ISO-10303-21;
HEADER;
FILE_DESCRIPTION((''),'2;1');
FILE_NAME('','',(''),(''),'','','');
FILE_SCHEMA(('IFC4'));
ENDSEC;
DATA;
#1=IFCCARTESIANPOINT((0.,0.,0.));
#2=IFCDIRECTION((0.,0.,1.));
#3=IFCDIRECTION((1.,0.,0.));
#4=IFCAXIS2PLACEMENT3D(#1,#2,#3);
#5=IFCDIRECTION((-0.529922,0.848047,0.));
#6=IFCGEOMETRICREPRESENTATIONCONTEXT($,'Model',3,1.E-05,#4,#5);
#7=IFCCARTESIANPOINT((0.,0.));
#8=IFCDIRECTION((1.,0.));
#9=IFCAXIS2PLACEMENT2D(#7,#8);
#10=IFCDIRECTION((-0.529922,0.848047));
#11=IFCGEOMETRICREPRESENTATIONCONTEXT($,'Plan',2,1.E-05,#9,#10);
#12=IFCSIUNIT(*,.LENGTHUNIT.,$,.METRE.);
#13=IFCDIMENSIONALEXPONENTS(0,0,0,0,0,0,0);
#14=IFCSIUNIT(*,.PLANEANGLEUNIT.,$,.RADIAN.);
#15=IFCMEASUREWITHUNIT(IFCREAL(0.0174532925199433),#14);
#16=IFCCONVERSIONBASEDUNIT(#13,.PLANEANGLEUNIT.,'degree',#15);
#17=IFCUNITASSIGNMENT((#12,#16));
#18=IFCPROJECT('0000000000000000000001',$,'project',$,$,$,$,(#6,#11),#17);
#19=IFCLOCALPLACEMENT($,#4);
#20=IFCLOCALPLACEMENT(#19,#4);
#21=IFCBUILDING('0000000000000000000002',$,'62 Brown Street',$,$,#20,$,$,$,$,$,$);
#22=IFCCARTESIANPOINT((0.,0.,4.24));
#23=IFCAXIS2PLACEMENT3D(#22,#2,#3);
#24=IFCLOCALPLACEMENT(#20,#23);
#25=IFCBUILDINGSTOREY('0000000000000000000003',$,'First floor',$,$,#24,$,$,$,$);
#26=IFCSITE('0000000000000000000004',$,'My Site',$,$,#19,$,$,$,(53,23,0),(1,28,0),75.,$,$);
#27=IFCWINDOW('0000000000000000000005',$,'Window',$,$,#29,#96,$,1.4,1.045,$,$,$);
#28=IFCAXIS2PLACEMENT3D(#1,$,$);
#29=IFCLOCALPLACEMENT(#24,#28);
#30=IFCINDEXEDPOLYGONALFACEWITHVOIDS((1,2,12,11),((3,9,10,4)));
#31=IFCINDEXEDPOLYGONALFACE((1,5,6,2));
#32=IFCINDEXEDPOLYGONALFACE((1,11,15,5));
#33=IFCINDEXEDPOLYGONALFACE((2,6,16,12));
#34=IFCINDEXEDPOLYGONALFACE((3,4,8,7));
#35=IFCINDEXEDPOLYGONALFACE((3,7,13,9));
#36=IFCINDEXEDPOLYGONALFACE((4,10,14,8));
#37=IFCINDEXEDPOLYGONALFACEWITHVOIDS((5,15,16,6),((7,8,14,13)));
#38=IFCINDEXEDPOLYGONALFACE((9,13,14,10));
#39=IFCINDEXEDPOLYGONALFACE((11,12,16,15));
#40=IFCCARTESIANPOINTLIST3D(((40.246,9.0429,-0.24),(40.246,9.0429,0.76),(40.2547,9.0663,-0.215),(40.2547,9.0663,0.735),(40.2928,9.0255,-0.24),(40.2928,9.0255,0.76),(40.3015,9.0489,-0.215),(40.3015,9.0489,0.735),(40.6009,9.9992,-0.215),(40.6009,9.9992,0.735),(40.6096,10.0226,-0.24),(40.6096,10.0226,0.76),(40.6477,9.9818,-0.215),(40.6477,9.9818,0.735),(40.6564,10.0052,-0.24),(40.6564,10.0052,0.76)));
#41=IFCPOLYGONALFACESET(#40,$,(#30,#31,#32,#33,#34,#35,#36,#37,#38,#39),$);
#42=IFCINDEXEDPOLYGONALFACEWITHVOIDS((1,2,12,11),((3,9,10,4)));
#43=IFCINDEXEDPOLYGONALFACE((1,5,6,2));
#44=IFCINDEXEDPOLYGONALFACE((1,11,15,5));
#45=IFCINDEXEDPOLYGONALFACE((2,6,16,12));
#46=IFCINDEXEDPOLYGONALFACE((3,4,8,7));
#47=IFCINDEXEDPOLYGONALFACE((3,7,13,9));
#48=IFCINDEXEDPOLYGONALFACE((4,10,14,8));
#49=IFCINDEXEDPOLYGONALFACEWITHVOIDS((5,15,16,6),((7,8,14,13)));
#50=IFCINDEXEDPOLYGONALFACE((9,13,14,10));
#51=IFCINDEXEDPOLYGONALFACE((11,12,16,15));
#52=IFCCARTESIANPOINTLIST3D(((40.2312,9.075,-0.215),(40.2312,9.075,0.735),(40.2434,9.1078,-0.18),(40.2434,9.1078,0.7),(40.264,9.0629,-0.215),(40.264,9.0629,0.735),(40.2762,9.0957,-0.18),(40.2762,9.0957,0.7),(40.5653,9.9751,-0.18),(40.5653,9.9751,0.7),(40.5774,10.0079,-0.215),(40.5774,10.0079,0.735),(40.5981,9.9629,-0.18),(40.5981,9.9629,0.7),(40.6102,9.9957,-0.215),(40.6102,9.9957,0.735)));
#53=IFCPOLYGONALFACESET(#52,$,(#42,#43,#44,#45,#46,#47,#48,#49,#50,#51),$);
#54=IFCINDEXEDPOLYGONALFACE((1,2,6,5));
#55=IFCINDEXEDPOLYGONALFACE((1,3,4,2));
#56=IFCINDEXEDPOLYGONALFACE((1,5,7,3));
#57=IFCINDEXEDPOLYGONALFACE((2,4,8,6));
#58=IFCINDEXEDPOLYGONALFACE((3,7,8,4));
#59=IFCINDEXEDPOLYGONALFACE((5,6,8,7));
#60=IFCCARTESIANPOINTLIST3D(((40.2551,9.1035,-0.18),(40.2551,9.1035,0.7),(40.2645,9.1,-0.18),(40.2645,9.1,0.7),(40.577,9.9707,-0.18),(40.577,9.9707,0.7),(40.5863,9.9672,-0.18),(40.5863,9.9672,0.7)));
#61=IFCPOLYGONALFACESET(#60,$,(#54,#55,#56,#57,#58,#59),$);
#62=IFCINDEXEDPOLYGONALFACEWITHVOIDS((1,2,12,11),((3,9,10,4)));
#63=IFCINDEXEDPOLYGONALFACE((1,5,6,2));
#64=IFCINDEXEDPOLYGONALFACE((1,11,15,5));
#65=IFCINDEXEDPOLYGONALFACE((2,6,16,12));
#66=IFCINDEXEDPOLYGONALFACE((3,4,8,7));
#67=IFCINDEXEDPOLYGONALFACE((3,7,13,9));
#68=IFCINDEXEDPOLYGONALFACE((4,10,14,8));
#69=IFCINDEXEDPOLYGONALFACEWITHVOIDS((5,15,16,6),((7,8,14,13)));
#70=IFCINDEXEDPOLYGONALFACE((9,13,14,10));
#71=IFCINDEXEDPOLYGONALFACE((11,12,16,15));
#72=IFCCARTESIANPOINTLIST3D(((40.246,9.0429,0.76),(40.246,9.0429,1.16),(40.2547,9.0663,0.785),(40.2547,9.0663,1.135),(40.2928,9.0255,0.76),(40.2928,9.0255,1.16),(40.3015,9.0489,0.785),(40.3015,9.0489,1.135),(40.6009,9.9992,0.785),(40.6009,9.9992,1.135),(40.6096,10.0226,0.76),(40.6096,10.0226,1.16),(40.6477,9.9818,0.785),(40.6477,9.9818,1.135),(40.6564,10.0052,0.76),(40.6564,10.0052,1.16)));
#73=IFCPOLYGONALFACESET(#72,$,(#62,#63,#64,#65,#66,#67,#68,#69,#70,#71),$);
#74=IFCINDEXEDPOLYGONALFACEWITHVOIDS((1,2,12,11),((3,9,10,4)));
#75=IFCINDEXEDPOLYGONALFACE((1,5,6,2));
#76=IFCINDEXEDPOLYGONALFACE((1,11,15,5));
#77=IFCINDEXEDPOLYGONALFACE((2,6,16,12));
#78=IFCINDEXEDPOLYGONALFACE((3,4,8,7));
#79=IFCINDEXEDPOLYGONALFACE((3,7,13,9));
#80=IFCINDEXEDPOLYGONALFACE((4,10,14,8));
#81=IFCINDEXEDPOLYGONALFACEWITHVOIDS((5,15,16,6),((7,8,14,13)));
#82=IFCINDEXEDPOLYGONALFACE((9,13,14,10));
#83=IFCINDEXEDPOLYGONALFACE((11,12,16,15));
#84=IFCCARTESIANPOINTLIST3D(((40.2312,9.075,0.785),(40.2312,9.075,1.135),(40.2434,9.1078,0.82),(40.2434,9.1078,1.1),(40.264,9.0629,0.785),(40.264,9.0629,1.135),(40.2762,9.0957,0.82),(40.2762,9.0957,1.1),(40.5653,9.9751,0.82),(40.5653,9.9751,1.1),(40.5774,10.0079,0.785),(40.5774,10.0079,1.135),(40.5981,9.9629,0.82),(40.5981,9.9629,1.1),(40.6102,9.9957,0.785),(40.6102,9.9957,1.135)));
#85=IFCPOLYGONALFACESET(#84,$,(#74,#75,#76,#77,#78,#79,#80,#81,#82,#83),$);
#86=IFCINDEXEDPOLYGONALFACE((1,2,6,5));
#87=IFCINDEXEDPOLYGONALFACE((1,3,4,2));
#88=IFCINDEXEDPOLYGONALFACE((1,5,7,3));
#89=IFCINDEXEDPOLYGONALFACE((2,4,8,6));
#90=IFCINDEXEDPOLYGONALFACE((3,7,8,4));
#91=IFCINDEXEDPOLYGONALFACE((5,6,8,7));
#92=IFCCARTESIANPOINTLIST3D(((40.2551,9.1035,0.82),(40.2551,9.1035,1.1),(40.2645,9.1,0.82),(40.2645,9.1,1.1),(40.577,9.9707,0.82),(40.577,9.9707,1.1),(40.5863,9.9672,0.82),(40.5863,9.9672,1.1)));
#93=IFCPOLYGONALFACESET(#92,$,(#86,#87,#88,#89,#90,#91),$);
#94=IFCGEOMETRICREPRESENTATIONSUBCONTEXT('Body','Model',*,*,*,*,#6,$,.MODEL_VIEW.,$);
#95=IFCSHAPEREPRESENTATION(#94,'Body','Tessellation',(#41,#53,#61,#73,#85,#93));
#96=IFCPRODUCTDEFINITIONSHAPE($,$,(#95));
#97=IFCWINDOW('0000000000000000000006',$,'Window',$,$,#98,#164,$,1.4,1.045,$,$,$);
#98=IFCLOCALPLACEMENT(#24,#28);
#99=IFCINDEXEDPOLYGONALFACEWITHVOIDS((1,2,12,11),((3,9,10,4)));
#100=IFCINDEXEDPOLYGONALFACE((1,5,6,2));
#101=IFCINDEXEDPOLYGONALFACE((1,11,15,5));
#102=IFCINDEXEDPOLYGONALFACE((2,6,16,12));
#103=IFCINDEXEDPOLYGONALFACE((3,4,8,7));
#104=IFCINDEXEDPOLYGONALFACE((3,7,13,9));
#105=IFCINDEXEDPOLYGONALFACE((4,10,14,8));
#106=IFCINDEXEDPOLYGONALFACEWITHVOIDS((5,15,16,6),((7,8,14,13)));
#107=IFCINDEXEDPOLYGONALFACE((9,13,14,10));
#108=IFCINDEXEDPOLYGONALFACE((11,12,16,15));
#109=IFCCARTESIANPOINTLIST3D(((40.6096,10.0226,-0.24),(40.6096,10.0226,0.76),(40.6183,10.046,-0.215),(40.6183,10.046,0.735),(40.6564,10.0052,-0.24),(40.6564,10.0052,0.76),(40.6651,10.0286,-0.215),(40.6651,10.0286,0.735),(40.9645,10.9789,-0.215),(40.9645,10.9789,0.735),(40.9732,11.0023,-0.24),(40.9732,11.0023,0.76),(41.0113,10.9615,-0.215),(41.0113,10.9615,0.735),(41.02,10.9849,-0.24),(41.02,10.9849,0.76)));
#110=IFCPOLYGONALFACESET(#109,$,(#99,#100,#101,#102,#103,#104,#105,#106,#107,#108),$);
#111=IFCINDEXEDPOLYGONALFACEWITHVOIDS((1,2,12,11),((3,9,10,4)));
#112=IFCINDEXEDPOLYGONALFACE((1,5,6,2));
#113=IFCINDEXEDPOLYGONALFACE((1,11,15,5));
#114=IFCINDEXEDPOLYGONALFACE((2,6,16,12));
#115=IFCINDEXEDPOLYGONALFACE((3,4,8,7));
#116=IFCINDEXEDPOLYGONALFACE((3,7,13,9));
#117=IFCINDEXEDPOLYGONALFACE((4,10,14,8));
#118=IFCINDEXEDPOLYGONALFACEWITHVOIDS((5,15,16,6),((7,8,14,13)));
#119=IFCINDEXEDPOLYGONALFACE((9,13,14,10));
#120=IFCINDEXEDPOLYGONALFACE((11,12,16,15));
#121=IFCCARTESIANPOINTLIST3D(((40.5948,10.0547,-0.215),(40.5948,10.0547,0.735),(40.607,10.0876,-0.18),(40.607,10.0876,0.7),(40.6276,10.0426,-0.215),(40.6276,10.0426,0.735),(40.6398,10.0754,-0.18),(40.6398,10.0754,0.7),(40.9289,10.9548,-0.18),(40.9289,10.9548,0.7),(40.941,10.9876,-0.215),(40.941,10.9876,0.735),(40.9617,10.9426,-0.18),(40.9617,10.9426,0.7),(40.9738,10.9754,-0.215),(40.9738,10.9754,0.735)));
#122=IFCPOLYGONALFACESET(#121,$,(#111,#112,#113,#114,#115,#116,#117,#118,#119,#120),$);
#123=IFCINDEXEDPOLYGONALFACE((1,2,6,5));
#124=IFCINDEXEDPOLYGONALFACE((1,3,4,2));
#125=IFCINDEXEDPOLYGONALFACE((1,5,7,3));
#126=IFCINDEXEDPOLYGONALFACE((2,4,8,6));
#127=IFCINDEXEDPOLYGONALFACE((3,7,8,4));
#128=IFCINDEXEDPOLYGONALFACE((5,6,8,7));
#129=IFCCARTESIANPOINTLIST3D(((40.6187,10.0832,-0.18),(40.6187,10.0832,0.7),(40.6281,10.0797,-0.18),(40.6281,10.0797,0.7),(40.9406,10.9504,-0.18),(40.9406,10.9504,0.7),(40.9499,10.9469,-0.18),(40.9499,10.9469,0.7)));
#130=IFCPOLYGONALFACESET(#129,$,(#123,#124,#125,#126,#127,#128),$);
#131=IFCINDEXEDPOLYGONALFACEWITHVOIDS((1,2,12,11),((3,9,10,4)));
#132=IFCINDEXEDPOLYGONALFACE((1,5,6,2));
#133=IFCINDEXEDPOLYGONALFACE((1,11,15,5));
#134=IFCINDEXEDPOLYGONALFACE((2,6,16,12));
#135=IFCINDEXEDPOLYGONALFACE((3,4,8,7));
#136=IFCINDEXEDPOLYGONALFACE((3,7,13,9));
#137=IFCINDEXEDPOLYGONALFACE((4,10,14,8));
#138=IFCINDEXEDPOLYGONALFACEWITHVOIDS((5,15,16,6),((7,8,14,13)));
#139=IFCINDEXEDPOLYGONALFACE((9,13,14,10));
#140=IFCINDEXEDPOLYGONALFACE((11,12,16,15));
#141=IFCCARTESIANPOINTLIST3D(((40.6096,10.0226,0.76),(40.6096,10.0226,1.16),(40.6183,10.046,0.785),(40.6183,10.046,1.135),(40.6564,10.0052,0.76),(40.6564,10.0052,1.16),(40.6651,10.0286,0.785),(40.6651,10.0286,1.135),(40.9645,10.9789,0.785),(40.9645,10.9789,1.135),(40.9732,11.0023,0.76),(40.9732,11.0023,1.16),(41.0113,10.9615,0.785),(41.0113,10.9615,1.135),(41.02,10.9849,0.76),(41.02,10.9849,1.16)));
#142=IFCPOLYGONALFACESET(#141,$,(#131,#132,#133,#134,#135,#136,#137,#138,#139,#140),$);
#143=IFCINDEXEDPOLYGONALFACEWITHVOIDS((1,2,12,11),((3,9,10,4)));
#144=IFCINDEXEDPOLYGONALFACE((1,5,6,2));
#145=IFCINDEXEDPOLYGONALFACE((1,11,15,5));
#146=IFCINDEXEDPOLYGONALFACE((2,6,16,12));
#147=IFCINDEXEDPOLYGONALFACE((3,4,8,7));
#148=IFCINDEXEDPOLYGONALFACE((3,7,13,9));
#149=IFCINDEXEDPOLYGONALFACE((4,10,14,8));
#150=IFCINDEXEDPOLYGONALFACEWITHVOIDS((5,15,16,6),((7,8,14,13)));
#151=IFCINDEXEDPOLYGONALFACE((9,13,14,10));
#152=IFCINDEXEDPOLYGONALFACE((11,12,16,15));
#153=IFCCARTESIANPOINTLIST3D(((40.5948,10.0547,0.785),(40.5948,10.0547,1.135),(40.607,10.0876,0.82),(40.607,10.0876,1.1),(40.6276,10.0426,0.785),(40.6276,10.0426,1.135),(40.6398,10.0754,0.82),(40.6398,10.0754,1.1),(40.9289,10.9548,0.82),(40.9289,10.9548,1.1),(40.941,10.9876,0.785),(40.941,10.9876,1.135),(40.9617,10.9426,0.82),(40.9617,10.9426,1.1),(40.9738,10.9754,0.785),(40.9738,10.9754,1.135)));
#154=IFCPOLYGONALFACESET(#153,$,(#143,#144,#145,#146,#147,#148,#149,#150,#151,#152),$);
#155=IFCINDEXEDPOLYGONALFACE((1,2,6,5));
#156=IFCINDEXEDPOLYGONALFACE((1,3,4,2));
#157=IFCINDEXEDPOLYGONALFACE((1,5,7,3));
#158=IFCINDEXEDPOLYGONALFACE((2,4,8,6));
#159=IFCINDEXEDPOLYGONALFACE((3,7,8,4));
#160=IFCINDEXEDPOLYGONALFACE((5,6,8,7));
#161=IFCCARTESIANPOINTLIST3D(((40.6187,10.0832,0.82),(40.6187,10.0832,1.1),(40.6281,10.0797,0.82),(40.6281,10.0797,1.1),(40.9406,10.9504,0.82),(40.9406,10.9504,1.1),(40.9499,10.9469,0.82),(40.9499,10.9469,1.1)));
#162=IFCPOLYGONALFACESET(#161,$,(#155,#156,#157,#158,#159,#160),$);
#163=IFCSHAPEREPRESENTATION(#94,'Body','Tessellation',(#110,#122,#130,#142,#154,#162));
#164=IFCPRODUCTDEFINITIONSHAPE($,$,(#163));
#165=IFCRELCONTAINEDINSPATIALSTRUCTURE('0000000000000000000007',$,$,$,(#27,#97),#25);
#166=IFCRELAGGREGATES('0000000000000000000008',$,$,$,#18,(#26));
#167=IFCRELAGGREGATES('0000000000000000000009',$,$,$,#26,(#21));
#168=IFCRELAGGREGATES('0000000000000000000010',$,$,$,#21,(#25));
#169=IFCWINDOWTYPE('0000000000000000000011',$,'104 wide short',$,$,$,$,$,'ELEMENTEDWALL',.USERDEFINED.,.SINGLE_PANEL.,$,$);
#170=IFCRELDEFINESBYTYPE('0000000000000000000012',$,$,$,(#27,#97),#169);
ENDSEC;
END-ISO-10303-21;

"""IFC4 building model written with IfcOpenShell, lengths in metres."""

from ifc_helpers import new_model, entity, si_unit, converted_unit, direction, frame, origin_with_axes, origin_2d_with_axis, place, context, subcontext, project, spatial, line, indexed_curve, outline, extrude, shape, source, transform, mapped, type_object, type_shapes, element, save


model = new_model("IFC4")

# Units and contexts
model_context = context("Model", 3, precision=1e-05, world=origin_with_axes(), true_north=direction((-0.529922, 0.848047, 0.0)))
plan_context = context("Plan", 2, precision=1e-05, world=origin_2d_with_axis(), true_north=direction((-0.529922, 0.848047)))
body_context_1 = subcontext(model_context, "Body", "Model", "MODEL_VIEW")
body_context_2 = subcontext(plan_context, "Body", "Plan", "PLAN_VIEW")
ifc_project = project(units=[si_unit("LENGTHUNIT", "METRE"), converted_unit("PLANEANGLEUNIT", "degree", entity("IfcReal", 0.0174532925199433), si_unit("PLANEANGLEUNIT", "RADIAN"), dimensions=[0, 0, 0, 0, 0, 0, 0])], contexts=[model_context, plan_context])

# Site, building, storey
site_placement = place(None, origin_with_axes())
site = spatial("IfcSite", under=ifc_project, at=site_placement, Name="My Site", RefLatitude=(53, 23, 0), RefLongitude=(1, 28, 0), RefElevation=75.0)
building_placement = place(site_placement, origin_with_axes())
building = spatial("IfcBuilding", under=site, at=building_placement, Name="62 Brown Street")
storey_placement = place(building_placement, frame((0.0, 0.0, 4.24), z_axis=(0.0, 0.0, 1.0), x_axis=(1.0, 0.0, 0.0)))
storey = spatial("IfcBuildingStorey", under=building, at=storey_placement, Name="First floor")

# Windows
window_type = type_object("IfcWindowType", Name="104 wide short", ElementType="ELEMENTEDWALL", PartitioningType="SINGLE_PANEL", PredefinedType="USERDEFINED")
shared_shape_1 = source(origin_with_axes(), body_context_1, "Body", "SweptSolid", [
    extrude(outline(indexed_curve([(0.0, 0.0), (1.045, 0.0), (1.045, 1.0), (0.0, 1.0)], segments=[line(1, 2, 3, 4, 1)]), holes=[indexed_curve([(0.025, 0.025), (1.02, 0.025), (1.02, 0.975), (0.025, 0.975)], segments=[line(1, 2, 3, 4, 1)])]), frame((0.0, 0.15, 0.0), z_axis=(0.0, -1.0, 0.0), x_axis=(1.0, 0.0, 0.0)), (0.0, 0.0, -1.0), 0.05),
    extrude(outline(indexed_curve([(0.0, 0.0), (0.995, 0.0), (0.995, 0.95), (0.0, 0.95)], segments=[line(1, 2, 3, 4, 1)]), holes=[indexed_curve([(0.035, 0.035), (0.96, 0.035), (0.96, 0.915), (0.035, 0.915)], segments=[line(1, 2, 3, 4, 1)])]), frame((0.025, 0.19, 0.025), z_axis=(0.0, -1.0, 0.0), x_axis=(1.0, 0.0, 0.0)), (0.0, 0.0, -1.0), 0.035),
    extrude(outline(indexed_curve([(0.035, 0.035), (0.96, 0.035), (0.96, 0.915), (0.035, 0.915)], segments=[line(1, 2, 3, 4, 1)])), frame((0.025, 0.2025, 0.025), z_axis=(0.0, -1.0, 0.0), x_axis=(1.0, 0.0, 0.0)), (0.0, 0.0, -1.0), 0.01),
    extrude(outline(indexed_curve([(0.0, 0.0), (1.045, 0.0), (1.045, 0.4), (0.0, 0.4)], segments=[line(1, 2, 3, 4, 1)]), holes=[indexed_curve([(0.025, 0.025), (1.02, 0.025), (1.02, 0.375), (0.025, 0.375)], segments=[line(1, 2, 3, 4, 1)])]), frame((0.0, 0.15, 1.0), z_axis=(0.0, -1.0, 0.0), x_axis=(1.0, 0.0, 0.0)), (0.0, 0.0, -1.0), 0.05),
    extrude(outline(indexed_curve([(0.0, 0.0), (0.995, 0.0), (0.995, 0.35), (0.0, 0.35)], segments=[line(1, 2, 3, 4, 1)]), holes=[indexed_curve([(0.035, 0.035), (0.96, 0.035), (0.96, 0.315), (0.035, 0.315)], segments=[line(1, 2, 3, 4, 1)])]), frame((0.025, 0.19, 1.025), z_axis=(0.0, -1.0, 0.0), x_axis=(1.0, 0.0, 0.0)), (0.0, 0.0, -1.0), 0.035),
    extrude(outline(indexed_curve([(0.035, 0.035), (0.96, 0.035), (0.96, 0.315), (0.035, 0.315)], segments=[line(1, 2, 3, 4, 1)])), frame((0.025, 0.2025, 1.025), z_axis=(0.0, -1.0, 0.0), x_axis=(1.0, 0.0, 0.0)), (0.0, 0.0, -1.0), 0.01),
])
shared_shape_2 = source(origin_with_axes(), body_context_2, "Body", "Curve2D", [
    entity("IfcIndexedPolyCurve", entity("IfcCartesianPointList2D", [[0.025, 0.15], [1.02, 0.15]])),
    entity("IfcIndexedPolyCurve", entity("IfcCartesianPointList2D", [[0.0, 0.2], [0.025, 0.2], [0.025, 0.15], [0.0, 0.15]]), [entity("IfcLineIndex", [1, 2, 3, 4, 1])]),
    entity("IfcIndexedPolyCurve", entity("IfcCartesianPointList2D", [[1.045, 0.2], [1.02, 0.2], [1.02, 0.15], [1.045, 0.15]]), [entity("IfcLineIndex", [1, 2, 3, 4, 1])]),
    entity("IfcIndexedPolyCurve", entity("IfcCartesianPointList2D", [[0.025, 0.19], [0.06, 0.19], [0.06, 0.225], [0.025, 0.225]]), [entity("IfcLineIndex", [1, 2, 3, 4, 1])]),
    entity("IfcIndexedPolyCurve", entity("IfcCartesianPointList2D", [[1.02, 0.19], [0.985, 0.19], [0.985, 0.225], [1.02, 0.225]]), [entity("IfcLineIndex", [1, 2, 3, 4, 1])]),
    entity("IfcIndexedPolyCurve", entity("IfcCartesianPointList2D", [[0.06, 0.19], [0.985, 0.19]])),
    entity("IfcIndexedPolyCurve", entity("IfcCartesianPointList2D", [[0.06, 0.225], [0.985, 0.225]])),
    entity("IfcIndexedPolyCurve", entity("IfcCartesianPointList2D", [[0.06, 0.2075], [0.985, 0.2075]])),
])
type_shapes(window_type, [shared_shape_1, shared_shape_2])
for number, where, z_axis, x_axis, name in (
    (1, (40.4335, 8.9733, -0.24), (0.0, 0.0, 1.0), (0.347944, 0.937515, 0.0), "Window"),
    (2, (40.7971, 9.953, -0.24), (0.0, 0.0, 1.0), (0.347944, 0.937515, 0.0), "Window"),
):
    element("IfcWindow", number, at=place(storey_placement, frame(where, z_axis=z_axis, x_axis=x_axis)), inside=storey, type_object=window_type, Name=name, OverallHeight=1.4, OverallWidth=1.045, shapes=[
        shape(body_context_1, "Body", "MappedRepresentation", [mapped(shared_shape_1, transform((0.0, 0.0, 0.0), x_axis=(1.0, 0.0, 0.0), y_axis=(0.0, 1.0, 0.0), z_axis=(0.0, 0.0, 1.0), scale=1.0))]),
        shape(body_context_2, "Body", "MappedRepresentation", [mapped(shared_shape_2, transform((0.0, 0.0, 0.0), x_axis=(1.0, 0.0, 0.0), y_axis=(0.0, 1.0, 0.0), z_axis=(0.0, 0.0, 1.0), scale=1.0))]),
    ])

save(model, "model.ifc")
